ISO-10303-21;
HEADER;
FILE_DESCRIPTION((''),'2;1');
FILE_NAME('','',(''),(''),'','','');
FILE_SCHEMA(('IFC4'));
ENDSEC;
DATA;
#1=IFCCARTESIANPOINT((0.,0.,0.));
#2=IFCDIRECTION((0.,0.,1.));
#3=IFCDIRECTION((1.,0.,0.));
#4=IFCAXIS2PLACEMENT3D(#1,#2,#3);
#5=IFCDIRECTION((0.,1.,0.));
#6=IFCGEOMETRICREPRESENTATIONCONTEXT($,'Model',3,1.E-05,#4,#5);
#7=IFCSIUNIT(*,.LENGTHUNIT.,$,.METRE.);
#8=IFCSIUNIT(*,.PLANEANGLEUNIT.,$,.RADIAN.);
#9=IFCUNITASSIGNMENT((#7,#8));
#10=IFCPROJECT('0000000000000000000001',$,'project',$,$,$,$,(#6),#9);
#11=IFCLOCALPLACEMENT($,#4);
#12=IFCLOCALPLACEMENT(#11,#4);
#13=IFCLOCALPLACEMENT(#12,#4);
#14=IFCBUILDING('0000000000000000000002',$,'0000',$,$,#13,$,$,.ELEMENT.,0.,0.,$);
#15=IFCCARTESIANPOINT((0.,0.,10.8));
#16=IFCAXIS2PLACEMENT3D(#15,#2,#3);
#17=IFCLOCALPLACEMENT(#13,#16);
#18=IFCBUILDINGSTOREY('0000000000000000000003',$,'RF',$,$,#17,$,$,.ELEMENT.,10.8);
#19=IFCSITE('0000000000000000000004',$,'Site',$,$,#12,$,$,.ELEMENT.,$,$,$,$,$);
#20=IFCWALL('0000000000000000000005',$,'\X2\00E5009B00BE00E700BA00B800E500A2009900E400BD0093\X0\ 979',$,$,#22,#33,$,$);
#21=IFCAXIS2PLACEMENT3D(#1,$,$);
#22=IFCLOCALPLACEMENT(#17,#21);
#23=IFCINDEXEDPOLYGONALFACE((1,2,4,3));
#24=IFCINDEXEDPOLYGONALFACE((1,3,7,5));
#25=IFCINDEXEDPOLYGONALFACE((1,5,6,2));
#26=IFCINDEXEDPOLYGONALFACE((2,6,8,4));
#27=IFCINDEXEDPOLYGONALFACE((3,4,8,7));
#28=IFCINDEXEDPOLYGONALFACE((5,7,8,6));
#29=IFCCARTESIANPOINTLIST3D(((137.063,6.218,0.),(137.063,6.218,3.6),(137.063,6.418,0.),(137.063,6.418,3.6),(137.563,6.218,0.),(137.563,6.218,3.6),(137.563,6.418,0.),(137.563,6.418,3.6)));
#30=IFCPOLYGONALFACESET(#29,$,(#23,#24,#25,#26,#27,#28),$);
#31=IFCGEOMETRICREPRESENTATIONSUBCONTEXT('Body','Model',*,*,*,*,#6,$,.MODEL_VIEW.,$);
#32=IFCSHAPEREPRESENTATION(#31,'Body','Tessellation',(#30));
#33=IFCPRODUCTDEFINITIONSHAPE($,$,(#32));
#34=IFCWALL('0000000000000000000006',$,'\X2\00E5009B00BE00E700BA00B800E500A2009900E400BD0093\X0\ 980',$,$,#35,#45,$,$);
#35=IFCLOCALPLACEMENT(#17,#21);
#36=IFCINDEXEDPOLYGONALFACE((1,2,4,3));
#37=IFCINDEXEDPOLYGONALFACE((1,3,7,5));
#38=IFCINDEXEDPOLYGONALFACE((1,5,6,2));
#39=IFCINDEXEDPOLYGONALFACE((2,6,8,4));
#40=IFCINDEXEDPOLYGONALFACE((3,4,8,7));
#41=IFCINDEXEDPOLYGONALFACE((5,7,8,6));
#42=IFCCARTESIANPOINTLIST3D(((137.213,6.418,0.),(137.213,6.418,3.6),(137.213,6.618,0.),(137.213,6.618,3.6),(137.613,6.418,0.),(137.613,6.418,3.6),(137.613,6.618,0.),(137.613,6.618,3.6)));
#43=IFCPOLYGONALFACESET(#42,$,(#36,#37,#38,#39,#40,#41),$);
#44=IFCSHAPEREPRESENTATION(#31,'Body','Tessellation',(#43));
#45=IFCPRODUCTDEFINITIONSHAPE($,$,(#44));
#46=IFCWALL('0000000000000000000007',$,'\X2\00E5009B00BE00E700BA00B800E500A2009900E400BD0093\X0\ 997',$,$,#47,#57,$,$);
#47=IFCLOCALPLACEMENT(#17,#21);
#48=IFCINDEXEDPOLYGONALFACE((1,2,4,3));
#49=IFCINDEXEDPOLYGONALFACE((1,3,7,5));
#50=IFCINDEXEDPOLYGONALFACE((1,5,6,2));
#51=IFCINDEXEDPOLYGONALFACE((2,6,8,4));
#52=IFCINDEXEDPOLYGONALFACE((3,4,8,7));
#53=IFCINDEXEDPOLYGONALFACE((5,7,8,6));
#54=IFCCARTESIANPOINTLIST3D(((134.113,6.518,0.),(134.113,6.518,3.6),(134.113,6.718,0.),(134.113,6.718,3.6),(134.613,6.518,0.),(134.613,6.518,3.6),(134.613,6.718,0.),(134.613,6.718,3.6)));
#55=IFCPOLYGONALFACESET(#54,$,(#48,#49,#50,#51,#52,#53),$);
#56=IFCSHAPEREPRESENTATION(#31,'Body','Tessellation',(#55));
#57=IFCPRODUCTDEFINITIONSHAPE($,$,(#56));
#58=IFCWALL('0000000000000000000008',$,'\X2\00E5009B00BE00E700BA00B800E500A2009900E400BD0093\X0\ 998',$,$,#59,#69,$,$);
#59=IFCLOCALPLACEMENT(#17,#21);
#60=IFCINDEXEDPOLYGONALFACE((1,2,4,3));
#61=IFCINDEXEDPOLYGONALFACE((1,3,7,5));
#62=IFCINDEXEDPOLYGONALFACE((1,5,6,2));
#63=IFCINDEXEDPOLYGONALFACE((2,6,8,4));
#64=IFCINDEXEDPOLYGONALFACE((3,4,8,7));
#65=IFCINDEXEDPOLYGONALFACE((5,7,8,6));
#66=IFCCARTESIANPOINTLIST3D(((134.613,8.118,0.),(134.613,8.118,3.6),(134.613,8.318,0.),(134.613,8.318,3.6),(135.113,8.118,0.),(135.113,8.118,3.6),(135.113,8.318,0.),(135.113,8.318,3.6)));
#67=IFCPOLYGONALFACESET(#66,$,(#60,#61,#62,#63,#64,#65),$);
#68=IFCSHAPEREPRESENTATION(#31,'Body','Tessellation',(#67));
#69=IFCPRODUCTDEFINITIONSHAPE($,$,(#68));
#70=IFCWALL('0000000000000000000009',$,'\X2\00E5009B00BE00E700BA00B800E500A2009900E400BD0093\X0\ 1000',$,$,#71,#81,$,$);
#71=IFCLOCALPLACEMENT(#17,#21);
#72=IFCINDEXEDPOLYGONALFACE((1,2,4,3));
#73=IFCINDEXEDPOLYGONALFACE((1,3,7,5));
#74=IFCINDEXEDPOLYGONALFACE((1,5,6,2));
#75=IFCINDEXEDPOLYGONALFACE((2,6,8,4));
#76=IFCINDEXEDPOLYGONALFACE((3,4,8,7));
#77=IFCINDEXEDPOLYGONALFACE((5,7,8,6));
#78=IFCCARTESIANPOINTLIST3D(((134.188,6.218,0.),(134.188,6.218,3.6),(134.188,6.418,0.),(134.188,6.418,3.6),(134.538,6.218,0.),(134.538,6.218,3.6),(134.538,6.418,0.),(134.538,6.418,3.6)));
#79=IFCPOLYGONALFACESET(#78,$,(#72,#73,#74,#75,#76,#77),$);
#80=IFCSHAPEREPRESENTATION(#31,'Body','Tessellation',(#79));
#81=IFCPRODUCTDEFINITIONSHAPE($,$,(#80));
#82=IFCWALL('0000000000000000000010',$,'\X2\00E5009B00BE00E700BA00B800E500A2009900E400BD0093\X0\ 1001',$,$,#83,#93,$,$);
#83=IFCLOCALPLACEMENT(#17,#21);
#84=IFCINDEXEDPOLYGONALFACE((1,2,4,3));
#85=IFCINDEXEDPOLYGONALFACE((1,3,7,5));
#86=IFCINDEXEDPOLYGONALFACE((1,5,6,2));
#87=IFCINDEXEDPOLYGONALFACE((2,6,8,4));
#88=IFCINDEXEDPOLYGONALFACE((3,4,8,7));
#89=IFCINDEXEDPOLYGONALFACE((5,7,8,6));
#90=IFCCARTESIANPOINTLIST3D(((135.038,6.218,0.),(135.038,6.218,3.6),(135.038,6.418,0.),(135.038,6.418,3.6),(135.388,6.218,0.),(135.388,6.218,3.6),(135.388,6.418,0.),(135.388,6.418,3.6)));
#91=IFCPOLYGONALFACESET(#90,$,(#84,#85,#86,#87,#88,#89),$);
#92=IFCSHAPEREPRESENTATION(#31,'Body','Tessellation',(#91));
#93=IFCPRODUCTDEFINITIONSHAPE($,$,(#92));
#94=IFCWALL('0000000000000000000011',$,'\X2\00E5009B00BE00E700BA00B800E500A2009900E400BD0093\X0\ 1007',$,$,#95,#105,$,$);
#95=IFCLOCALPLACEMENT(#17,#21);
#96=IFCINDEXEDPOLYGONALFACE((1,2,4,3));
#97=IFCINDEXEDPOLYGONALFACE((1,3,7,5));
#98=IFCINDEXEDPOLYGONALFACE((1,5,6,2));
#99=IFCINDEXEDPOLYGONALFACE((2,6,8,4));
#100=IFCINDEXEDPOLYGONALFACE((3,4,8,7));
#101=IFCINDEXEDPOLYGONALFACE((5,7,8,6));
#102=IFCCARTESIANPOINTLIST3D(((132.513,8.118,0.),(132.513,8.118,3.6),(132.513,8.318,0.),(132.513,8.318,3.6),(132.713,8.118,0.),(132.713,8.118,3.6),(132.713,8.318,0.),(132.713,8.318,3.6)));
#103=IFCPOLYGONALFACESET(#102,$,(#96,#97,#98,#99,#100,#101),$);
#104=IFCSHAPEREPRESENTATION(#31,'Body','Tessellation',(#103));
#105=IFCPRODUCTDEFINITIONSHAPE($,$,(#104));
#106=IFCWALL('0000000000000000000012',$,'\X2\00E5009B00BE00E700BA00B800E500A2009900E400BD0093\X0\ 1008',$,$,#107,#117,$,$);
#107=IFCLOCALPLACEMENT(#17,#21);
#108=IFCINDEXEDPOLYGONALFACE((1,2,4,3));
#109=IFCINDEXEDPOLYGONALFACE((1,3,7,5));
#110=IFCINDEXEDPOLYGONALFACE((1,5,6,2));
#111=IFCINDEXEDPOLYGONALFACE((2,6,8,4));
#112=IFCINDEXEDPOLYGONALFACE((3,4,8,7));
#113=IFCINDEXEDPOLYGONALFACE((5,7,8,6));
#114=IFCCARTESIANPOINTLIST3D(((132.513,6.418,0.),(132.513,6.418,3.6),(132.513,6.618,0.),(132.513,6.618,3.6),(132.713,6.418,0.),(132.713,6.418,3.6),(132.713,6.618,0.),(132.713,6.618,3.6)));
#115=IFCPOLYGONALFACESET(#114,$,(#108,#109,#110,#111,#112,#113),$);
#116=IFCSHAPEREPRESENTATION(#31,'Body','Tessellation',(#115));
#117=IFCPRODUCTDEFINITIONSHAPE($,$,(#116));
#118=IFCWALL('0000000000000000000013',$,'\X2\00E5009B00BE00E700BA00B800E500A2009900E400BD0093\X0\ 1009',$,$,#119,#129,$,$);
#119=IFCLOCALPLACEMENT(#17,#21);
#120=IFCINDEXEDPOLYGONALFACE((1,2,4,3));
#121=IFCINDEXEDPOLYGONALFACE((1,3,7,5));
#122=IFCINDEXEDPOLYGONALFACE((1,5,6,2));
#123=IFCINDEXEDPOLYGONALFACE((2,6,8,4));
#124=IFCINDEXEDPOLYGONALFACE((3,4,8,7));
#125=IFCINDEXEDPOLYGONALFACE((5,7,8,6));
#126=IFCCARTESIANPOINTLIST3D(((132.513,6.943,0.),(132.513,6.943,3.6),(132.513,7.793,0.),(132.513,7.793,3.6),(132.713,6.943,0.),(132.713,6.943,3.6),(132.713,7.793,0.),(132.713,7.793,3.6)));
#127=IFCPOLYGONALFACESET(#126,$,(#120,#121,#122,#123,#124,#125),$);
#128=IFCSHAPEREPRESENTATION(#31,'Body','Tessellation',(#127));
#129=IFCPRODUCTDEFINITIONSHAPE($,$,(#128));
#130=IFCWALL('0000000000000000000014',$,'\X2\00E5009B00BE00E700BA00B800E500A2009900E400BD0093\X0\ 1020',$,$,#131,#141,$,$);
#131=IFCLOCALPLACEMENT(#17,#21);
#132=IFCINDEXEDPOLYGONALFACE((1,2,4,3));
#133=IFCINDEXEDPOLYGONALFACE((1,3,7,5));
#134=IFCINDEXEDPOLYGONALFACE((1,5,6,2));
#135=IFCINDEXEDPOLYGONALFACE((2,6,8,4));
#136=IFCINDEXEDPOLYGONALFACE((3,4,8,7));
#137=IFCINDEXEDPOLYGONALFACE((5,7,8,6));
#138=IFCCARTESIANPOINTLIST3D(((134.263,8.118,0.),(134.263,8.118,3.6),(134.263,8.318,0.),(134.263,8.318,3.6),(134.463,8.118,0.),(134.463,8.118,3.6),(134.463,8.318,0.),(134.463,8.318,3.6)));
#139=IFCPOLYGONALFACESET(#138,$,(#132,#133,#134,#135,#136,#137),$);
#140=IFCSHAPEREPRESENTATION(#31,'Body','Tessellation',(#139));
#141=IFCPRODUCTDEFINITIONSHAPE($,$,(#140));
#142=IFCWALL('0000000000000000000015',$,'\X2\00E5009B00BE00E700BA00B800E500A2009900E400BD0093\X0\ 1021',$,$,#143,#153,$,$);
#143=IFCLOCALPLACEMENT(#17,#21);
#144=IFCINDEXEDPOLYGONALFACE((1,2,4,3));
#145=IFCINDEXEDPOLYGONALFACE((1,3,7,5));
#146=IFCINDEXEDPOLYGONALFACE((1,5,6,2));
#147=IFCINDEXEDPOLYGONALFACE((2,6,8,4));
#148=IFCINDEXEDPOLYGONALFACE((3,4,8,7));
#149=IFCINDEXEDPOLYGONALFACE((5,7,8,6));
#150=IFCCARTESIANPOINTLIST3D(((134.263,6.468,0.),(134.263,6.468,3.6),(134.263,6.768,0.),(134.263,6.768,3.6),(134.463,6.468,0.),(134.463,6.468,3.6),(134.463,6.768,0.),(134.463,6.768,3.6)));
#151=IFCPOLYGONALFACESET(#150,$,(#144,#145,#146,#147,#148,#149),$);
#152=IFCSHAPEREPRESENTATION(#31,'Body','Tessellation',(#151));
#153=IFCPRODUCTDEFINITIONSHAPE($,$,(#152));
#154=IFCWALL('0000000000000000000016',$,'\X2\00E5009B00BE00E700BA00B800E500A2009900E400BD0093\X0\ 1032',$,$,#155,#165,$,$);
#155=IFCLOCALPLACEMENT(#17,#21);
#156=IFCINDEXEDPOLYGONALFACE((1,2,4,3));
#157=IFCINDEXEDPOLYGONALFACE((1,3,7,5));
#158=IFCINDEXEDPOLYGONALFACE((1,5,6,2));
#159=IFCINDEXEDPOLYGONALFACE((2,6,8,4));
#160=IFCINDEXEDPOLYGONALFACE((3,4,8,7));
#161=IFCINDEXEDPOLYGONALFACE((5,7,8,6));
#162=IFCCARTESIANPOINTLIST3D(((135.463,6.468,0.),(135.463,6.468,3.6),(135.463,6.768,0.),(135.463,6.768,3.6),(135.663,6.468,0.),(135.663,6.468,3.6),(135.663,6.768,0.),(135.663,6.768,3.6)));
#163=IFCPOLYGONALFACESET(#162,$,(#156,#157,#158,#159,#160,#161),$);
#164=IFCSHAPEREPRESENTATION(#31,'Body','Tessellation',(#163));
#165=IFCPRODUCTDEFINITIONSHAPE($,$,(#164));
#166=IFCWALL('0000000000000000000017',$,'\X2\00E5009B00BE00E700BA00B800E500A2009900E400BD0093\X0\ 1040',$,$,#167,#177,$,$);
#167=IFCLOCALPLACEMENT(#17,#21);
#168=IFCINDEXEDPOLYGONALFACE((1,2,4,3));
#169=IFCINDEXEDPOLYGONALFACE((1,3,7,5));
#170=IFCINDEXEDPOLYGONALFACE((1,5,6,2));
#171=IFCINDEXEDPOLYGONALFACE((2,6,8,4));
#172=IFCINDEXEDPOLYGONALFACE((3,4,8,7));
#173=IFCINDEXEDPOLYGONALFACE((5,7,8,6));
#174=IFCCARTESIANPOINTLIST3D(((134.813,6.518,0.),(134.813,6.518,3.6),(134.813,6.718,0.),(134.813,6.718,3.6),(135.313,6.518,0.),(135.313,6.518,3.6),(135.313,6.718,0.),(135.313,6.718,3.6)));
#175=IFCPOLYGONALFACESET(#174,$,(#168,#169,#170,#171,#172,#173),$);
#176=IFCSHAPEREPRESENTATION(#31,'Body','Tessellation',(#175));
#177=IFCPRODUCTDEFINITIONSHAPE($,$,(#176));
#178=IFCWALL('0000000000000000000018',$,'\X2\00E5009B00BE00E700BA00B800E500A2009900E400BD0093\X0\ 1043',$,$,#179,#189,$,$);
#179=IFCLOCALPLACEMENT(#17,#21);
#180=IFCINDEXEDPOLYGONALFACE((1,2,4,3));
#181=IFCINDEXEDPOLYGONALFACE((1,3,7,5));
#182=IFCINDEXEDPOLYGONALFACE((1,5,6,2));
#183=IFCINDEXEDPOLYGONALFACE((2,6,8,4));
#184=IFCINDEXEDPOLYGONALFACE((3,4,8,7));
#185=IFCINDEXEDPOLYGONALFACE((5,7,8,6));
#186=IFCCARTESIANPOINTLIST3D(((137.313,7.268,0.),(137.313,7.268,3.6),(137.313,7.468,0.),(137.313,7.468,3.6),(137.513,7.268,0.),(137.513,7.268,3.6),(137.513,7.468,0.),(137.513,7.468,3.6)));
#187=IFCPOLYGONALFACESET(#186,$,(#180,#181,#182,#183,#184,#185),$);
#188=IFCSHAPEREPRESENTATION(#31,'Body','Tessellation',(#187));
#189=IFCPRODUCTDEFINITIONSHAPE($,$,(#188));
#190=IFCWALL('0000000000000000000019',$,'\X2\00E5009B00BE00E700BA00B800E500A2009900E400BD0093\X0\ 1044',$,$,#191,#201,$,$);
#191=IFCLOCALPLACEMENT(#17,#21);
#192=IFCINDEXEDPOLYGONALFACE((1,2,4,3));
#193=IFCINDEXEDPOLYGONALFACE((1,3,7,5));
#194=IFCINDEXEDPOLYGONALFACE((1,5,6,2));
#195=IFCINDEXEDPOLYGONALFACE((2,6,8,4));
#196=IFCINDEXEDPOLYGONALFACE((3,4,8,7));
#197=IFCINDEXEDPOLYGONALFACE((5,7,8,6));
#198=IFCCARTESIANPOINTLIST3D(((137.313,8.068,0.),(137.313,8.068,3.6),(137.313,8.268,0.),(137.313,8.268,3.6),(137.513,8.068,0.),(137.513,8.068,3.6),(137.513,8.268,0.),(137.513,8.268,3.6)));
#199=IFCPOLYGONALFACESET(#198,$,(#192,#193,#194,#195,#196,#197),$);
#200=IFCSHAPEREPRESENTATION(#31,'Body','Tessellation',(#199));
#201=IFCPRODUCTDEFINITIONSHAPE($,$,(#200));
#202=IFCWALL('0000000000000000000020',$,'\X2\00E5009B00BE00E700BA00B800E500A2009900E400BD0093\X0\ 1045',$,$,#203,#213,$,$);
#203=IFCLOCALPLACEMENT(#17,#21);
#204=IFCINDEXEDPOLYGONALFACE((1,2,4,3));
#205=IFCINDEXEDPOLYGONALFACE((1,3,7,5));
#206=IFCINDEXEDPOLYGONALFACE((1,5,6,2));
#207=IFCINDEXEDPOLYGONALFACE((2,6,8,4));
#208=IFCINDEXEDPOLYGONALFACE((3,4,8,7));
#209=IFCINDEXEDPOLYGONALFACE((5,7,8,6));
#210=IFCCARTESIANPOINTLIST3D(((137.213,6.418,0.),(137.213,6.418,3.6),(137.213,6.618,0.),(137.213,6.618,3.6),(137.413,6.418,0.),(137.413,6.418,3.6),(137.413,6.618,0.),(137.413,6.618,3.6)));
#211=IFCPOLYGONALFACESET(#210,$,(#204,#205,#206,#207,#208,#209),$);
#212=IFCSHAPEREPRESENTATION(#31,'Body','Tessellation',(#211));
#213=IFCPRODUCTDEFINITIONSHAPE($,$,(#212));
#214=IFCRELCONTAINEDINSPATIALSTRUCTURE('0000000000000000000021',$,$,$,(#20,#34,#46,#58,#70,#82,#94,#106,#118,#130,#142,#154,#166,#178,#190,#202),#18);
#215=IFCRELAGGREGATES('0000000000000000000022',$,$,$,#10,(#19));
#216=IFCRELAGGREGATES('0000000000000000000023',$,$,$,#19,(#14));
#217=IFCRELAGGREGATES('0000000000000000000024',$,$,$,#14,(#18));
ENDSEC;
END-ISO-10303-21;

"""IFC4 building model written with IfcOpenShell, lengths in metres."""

from ifc_helpers import new_model, si_unit, direction, frame, frame_2d, origin_with_axes, place, context, subcontext, project, spatial, rectangle, extrude, element, save


model = new_model("IFC4")

# Units and contexts
model_context = context("Model", 3, precision=1e-05, world=origin_with_axes(), true_north=direction((0.0, 1.0, 0.0)))
body_context = subcontext(model_context, "Body", "Model", "MODEL_VIEW")
ifc_project = project(units=[si_unit("LENGTHUNIT", "METRE"), si_unit("PLANEANGLEUNIT", "RADIAN")], contexts=[model_context])

# Site, building, storey
placement = place(None, origin_with_axes())
site_placement = place(placement, origin_with_axes())
site = spatial("IfcSite", under=ifc_project, at=site_placement, Name="Site", CompositionType="ELEMENT")
building_placement = place(site_placement, origin_with_axes())
building = spatial("IfcBuilding", under=site, at=building_placement, Name="0000", CompositionType="ELEMENT", ElevationOfRefHeight=0.0, ElevationOfTerrain=0.0)
storey_placement = place(building_placement, frame((0.0, 0.0, 10.8), z_axis=(0.0, 0.0, 1.0), x_axis=(1.0, 0.0, 0.0)))
storey = spatial("IfcBuildingStorey", under=building, at=storey_placement, Name="RF", CompositionType="ELEMENT", Elevation=10.8)

# Walls
wall_1_placement = place(storey_placement, frame((137.313, 6.318, 0.0), z_axis=(0.0, 0.0, 1.0), x_axis=(1.0, 0.0, 0.0)))
element("IfcWall", 1, at=wall_1_placement, inside=storey, Name="å\u009b¾çº¸å¢\u0099ä½\u0093 979", context=body_context, shape_type="SweptSolid", body=[
    extrude(rectangle(XDim=0.5, YDim=0.2, at=frame_2d((0.0, 0.0), x_axis=(1.0, 0.0, 0.0))), frame((0.0, 0.0, 0.0), z_axis=(0.0, 0.0, 1.0)), (0.0, 0.0, 1.0), 3.6),
])
wall_2_placement = place(storey_placement, frame((137.413, 6.518, 0.0), z_axis=(0.0, 0.0, 1.0), x_axis=(1.0, 0.0, 0.0)))
element("IfcWall", 2, at=wall_2_placement, inside=storey, Name="å\u009b¾çº¸å¢\u0099ä½\u0093 980", context=body_context, shape_type="SweptSolid", body=[
    extrude(rectangle(XDim=0.4, YDim=0.2, at=frame_2d((0.0, 0.0), x_axis=(1.0, 0.0, 0.0))), frame((0.0, 0.0, 0.0), z_axis=(0.0, 0.0, 1.0)), (0.0, 0.0, 1.0), 3.6),
])
for number, where, z_axis, x_axis, name in (
    (3, (134.363, 6.618, 0.0), (0.0, 0.0, 1.0), (1.0, 0.0, 0.0), "å\u009b¾çº¸å¢\u0099ä½\u0093 997"),
    (4, (134.863, 8.218, 0.0), (0.0, 0.0, 1.0), (-1.0, 0.0, 0.0), "å\u009b¾çº¸å¢\u0099ä½\u0093 998"),
):
    element("IfcWall", number, at=place(storey_placement, frame(where, z_axis=z_axis, x_axis=x_axis)), inside=storey, Name=name, context=body_context, shape_type="SweptSolid", body=[
        extrude(rectangle(XDim=0.5, YDim=0.2, at=frame_2d((0.0, 0.0), x_axis=(1.0, 0.0, 0.0))), frame((0.0, 0.0, 0.0), z_axis=(0.0, 0.0, 1.0)), (0.0, 0.0, 1.0), 3.6),
    ])
for number, where, z_axis, x_axis, name in (
    (5, (134.363, 6.318, 0.0), (0.0, 0.0, 1.0), (1.0, 0.0, 0.0), "å\u009b¾çº¸å¢\u0099ä½\u0093 1000"),
    (6, (135.213, 6.318, 0.0), (0.0, 0.0, 1.0), (1.0, 0.0, 0.0), "å\u009b¾çº¸å¢\u0099ä½\u0093 1001"),
):
    element("IfcWall", number, at=place(storey_placement, frame(where, z_axis=z_axis, x_axis=x_axis)), inside=storey, Name=name, context=body_context, shape_type="SweptSolid", body=[
        extrude(rectangle(XDim=0.35, YDim=0.2, at=frame_2d((0.0, 0.0), x_axis=(1.0, 0.0, 0.0))), frame((0.0, 0.0, 0.0), z_axis=(0.0, 0.0, 1.0)), (0.0, 0.0, 1.0), 3.6),
    ])
for number, where, z_axis, x_axis, name in (
    (7, (132.613, 8.218, 0.0), (0.0, 0.0, 1.0), (0.0, 1.0, 0.0), "å\u009b¾çº¸å¢\u0099ä½\u0093 1007"),
    (8, (132.613, 6.518, 0.0), (0.0, 0.0, 1.0), (0.0, -1.0, 0.0), "å\u009b¾çº¸å¢\u0099ä½\u0093 1008"),
):
    element("IfcWall", number, at=place(storey_placement, frame(where, z_axis=z_axis, x_axis=x_axis)), inside=storey, Name=name, context=body_context, shape_type="SweptSolid", body=[
        extrude(rectangle(XDim=0.2, YDim=0.2, at=frame_2d((0.0, 0.0), x_axis=(1.0, 0.0, 0.0))), frame((0.0, 0.0, 0.0), z_axis=(0.0, 0.0, 1.0)), (0.0, 0.0, 1.0), 3.6),
    ])
wall_3_placement = place(storey_placement, frame((132.613, 7.368, 0.0), z_axis=(0.0, 0.0, 1.0), x_axis=(0.0, -1.0, 0.0)))
element("IfcWall", 9, at=wall_3_placement, inside=storey, Name="å\u009b¾çº¸å¢\u0099ä½\u0093 1009", context=body_context, shape_type="SweptSolid", body=[
    extrude(rectangle(XDim=0.85, YDim=0.2, at=frame_2d((0.0, 0.0), x_axis=(1.0, 0.0, 0.0))), frame((0.0, 0.0, 0.0), z_axis=(0.0, 0.0, 1.0)), (0.0, 0.0, 1.0), 3.6),
])
for number, where, z_axis, x_axis, name in (
    (10, (134.363, 8.218, 0.0), (0.0, 0.0, 1.0), (0.0, 1.0, 0.0), "å\u009b¾çº¸å¢\u0099ä½\u0093 1020"),
):
    element("IfcWall", number, at=place(storey_placement, frame(where, z_axis=z_axis, x_axis=x_axis)), inside=storey, Name=name, context=body_context, shape_type="SweptSolid", body=[
        extrude(rectangle(XDim=0.2, YDim=0.2, at=frame_2d((0.0, 0.0), x_axis=(1.0, 0.0, 0.0))), frame((0.0, 0.0, 0.0), z_axis=(0.0, 0.0, 1.0)), (0.0, 0.0, 1.0), 3.6),
    ])
for number, where, z_axis, x_axis, name in (
    (11, (134.363, 6.618, 0.0), (0.0, 0.0, 1.0), (0.0, -1.0, 0.0), "å\u009b¾çº¸å¢\u0099ä½\u0093 1021"),
    (12, (135.563, 6.618, 0.0), (0.0, 0.0, 1.0), (0.0, -1.0, 0.0), "å\u009b¾çº¸å¢\u0099ä½\u0093 1032"),
):
    element("IfcWall", number, at=place(storey_placement, frame(where, z_axis=z_axis, x_axis=x_axis)), inside=storey, Name=name, context=body_context, shape_type="SweptSolid", body=[
        extrude(rectangle(XDim=0.3, YDim=0.2, at=frame_2d((0.0, 0.0), x_axis=(1.0, 0.0, 0.0))), frame((0.0, 0.0, 0.0), z_axis=(0.0, 0.0, 1.0)), (0.0, 0.0, 1.0), 3.6),
    ])
wall_4_placement = place(storey_placement, frame((135.063, 6.618, 0.0), z_axis=(0.0, 0.0, 1.0), x_axis=(1.0, 0.0, 0.0)))
element("IfcWall", 13, at=wall_4_placement, inside=storey, Name="å\u009b¾çº¸å¢\u0099ä½\u0093 1040", context=body_context, shape_type="SweptSolid", body=[
    extrude(rectangle(XDim=0.5, YDim=0.2, at=frame_2d((0.0, 0.0), x_axis=(1.0, 0.0, 0.0))), frame((0.0, 0.0, 0.0), z_axis=(0.0, 0.0, 1.0)), (0.0, 0.0, 1.0), 3.6),
])
for number, where, z_axis, x_axis, name in (
    (14, (137.413, 7.368, 0.0), (0.0, 0.0, 1.0), (-1.0, 0.0, 0.0), "å\u009b¾çº¸å¢\u0099ä½\u0093 1043"),
    (15, (137.413, 8.168, 0.0), (0.0, 0.0, 1.0), (-1.0, 0.0, 0.0), "å\u009b¾çº¸å¢\u0099ä½\u0093 1044"),
    (16, (137.313, 6.518, 0.0), (0.0, 0.0, 1.0), (0.0, -1.0, 0.0), "å\u009b¾çº¸å¢\u0099ä½\u0093 1045"),
):
    element("IfcWall", number, at=place(storey_placement, frame(where, z_axis=z_axis, x_axis=x_axis)), inside=storey, Name=name, context=body_context, shape_type="SweptSolid", body=[
        extrude(rectangle(XDim=0.2, YDim=0.2, at=frame_2d((0.0, 0.0), x_axis=(1.0, 0.0, 0.0))), frame((0.0, 0.0, 0.0), z_axis=(0.0, 0.0, 1.0)), (0.0, 0.0, 1.0), 3.6),
    ])

save(model, "model.ifc")
